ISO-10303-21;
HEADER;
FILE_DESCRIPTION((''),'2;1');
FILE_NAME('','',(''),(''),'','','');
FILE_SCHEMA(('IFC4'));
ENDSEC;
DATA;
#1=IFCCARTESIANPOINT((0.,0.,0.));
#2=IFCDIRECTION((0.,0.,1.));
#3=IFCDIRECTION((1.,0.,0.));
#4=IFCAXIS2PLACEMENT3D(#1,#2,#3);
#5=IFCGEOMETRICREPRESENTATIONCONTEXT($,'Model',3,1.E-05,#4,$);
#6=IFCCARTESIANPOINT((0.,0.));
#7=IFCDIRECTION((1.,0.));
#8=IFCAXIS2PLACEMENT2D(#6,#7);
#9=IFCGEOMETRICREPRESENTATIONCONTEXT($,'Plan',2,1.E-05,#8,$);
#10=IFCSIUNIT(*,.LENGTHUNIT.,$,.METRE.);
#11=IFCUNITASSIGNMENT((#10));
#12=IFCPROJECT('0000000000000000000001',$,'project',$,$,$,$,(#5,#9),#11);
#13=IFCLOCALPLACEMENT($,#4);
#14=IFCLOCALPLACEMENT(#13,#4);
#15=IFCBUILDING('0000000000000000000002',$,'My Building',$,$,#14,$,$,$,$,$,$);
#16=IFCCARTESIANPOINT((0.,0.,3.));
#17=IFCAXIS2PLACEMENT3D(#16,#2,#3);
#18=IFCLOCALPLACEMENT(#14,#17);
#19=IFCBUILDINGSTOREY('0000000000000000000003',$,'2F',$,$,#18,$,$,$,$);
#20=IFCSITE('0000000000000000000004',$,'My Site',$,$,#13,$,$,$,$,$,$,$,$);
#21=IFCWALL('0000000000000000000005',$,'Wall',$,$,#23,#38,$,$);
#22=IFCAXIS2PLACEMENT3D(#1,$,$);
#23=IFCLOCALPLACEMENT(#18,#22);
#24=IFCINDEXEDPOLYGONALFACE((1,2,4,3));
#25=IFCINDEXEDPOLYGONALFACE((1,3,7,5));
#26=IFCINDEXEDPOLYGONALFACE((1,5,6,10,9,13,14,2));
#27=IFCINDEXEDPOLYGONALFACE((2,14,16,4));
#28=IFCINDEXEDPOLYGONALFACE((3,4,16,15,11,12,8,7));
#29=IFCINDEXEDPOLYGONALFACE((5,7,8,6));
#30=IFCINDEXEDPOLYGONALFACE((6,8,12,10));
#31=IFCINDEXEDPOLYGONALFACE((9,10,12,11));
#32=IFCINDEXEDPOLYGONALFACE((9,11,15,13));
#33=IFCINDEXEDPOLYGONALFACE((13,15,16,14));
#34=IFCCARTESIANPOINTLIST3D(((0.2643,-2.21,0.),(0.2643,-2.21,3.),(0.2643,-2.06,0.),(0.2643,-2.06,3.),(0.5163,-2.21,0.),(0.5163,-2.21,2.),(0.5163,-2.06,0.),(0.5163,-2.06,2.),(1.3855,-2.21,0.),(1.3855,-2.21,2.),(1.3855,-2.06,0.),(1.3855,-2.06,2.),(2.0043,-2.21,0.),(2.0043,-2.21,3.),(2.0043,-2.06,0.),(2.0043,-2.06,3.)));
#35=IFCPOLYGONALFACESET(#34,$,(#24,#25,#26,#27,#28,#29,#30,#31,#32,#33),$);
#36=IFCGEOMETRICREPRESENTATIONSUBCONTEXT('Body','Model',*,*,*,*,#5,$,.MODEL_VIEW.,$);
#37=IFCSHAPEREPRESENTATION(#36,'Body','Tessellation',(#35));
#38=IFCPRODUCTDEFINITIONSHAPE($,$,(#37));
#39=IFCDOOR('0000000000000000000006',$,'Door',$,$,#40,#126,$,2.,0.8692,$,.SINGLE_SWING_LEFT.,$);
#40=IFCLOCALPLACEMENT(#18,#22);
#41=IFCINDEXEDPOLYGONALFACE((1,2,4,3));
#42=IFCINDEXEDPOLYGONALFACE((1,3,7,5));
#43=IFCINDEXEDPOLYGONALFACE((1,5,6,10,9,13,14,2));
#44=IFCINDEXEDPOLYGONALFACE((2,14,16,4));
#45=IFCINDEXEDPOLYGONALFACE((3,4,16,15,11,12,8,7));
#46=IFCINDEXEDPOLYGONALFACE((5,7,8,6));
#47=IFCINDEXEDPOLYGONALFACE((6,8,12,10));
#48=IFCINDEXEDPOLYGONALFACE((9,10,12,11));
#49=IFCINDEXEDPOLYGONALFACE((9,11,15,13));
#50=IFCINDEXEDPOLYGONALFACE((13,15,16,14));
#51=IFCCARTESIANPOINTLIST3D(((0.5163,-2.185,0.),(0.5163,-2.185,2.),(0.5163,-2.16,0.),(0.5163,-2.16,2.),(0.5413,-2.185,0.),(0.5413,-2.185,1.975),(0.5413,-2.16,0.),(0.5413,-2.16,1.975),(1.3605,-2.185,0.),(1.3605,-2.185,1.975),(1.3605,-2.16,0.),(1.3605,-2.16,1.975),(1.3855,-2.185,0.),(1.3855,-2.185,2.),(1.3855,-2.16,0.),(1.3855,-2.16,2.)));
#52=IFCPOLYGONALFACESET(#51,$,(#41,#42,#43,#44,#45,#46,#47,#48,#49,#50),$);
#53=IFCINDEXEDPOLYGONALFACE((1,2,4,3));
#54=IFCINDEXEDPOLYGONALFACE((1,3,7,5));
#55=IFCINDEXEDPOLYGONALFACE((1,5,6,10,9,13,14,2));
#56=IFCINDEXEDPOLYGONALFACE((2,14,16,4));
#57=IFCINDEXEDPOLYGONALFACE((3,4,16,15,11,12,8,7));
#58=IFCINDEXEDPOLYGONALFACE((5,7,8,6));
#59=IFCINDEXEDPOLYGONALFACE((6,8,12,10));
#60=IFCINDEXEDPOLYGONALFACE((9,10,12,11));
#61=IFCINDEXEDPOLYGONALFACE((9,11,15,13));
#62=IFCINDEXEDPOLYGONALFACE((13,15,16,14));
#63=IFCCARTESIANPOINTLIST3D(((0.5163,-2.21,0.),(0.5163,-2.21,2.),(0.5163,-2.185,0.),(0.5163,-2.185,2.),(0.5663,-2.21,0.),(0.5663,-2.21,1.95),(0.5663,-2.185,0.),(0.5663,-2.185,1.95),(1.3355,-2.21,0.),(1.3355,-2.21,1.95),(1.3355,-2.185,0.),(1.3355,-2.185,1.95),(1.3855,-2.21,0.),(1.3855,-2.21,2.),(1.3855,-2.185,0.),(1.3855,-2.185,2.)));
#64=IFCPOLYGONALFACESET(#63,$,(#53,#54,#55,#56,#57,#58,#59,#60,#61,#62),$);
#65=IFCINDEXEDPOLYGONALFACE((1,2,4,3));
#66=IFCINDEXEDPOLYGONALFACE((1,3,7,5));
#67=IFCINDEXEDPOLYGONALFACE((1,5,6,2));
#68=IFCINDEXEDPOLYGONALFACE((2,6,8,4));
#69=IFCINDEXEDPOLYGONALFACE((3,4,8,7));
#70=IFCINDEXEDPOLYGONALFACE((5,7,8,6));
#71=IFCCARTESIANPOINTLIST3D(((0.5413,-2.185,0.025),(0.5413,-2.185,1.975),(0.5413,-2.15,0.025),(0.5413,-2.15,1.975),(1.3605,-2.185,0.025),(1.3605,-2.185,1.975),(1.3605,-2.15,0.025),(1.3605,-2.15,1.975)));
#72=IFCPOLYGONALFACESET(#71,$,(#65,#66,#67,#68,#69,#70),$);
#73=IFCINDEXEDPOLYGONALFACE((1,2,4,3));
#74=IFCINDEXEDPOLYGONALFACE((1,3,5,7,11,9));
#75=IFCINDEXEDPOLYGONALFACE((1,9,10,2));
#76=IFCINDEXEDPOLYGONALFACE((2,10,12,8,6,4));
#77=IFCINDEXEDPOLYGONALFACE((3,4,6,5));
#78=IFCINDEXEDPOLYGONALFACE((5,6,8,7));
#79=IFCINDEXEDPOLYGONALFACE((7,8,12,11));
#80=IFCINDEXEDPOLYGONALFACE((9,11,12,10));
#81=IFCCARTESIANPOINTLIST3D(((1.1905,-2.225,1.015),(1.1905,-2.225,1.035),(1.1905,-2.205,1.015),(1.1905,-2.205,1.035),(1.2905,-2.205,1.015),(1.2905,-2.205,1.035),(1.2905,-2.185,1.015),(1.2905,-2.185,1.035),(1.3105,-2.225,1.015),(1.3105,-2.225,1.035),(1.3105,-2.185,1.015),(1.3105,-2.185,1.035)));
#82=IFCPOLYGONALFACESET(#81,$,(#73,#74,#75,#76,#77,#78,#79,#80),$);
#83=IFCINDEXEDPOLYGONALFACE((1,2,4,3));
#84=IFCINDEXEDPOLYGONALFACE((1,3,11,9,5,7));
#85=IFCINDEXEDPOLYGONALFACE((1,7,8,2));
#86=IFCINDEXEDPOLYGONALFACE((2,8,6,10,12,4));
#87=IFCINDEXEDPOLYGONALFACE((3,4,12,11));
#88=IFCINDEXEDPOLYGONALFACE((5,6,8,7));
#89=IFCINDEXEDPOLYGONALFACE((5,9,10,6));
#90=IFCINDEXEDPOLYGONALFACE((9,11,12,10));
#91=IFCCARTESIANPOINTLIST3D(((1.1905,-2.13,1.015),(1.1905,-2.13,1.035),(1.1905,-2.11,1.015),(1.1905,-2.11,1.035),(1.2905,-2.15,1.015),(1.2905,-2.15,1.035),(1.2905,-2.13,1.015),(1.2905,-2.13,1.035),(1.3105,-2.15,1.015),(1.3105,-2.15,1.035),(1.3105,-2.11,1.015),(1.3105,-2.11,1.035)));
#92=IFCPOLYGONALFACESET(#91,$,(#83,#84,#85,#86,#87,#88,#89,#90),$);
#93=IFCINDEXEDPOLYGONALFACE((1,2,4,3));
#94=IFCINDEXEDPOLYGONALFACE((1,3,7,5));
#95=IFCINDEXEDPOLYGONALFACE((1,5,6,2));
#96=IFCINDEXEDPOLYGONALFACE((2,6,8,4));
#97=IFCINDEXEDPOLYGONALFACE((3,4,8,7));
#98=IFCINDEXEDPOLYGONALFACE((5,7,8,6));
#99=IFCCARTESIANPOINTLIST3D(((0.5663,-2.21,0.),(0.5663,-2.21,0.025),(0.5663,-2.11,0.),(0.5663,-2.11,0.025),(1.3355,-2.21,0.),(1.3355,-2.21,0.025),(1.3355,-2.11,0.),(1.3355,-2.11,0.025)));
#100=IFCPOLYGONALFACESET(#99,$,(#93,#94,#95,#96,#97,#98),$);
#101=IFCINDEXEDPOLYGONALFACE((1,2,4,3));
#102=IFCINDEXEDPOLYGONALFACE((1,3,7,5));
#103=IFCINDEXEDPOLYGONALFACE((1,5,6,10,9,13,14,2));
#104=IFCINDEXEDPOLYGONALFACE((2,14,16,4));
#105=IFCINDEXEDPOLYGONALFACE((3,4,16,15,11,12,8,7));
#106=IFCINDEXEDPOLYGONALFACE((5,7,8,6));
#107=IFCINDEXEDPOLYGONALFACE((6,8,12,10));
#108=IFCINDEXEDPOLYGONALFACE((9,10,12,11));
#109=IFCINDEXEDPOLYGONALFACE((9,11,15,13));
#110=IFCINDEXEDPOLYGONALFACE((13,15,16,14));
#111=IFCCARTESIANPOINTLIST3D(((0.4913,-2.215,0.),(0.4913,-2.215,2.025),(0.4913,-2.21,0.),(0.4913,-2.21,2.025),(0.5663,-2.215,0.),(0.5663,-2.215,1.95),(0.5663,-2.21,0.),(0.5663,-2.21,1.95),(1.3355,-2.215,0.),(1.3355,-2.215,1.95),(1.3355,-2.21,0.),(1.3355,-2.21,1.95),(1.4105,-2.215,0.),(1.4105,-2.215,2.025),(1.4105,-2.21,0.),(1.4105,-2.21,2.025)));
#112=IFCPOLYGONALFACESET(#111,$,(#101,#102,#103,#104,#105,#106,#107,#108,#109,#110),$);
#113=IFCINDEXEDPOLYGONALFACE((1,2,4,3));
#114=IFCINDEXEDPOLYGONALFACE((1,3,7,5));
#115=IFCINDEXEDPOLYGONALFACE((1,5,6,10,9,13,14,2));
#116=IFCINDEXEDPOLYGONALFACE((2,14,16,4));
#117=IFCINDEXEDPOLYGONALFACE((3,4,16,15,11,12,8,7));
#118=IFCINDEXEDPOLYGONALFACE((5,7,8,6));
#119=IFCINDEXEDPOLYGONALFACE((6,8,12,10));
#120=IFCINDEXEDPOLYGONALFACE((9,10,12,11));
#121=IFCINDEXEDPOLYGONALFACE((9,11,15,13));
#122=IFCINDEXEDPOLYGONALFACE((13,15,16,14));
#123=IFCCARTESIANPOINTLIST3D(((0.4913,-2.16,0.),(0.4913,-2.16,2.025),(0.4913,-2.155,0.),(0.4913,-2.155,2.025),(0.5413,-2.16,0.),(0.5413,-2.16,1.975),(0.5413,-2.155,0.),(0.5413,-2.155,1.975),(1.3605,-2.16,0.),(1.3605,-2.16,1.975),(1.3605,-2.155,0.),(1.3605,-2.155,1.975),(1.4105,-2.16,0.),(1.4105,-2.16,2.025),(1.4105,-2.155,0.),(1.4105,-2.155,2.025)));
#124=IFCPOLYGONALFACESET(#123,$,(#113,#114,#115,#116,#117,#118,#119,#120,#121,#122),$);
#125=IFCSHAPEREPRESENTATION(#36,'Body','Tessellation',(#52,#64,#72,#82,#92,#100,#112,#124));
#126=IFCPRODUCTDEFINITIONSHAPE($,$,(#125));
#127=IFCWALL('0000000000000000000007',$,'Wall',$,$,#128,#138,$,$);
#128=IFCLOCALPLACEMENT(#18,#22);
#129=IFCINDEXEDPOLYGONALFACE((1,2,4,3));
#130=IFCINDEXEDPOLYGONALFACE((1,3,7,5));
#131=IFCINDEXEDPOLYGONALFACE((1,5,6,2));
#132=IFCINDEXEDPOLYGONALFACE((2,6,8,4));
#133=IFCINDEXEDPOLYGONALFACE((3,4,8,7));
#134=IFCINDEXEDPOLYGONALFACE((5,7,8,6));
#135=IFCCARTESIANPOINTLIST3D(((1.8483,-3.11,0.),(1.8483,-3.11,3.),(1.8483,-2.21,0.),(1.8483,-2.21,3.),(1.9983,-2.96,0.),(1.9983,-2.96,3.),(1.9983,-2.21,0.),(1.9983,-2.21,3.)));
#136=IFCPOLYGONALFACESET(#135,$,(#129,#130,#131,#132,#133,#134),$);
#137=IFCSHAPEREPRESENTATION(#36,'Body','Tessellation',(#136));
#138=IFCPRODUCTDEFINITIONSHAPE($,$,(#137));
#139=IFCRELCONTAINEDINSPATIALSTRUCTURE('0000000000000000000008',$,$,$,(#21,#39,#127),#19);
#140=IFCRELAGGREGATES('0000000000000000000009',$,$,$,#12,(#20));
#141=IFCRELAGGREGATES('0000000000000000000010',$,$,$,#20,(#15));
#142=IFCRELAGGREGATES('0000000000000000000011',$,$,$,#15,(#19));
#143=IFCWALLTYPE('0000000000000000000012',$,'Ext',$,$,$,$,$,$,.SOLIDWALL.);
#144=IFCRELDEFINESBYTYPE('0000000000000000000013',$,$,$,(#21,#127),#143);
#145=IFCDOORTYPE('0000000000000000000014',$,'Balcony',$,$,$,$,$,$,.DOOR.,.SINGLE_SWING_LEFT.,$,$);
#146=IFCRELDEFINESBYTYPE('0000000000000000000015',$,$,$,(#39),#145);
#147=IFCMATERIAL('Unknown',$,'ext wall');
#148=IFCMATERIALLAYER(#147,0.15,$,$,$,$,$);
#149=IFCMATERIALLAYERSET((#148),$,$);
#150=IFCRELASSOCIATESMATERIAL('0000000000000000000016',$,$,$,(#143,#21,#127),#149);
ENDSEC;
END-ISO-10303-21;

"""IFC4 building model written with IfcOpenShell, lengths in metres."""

from ifc_helpers import new_model, entity, si_unit, frame, origin_with_axes, origin_2d_with_axis, place, context, subcontext, project, spatial, line, indexed_curve, outline, extrude, shape, source, transform, mapped, material, layer, layer_set, layer_usage, type_object, type_shapes, element, fill, save


model = new_model("IFC4")

# Units and contexts
model_context = context("Model", 3, precision=1e-05, world=origin_with_axes())
plan_context = context("Plan", 2, precision=1e-05, world=origin_2d_with_axis())
body_context_1 = subcontext(model_context, "Body", "Model", "MODEL_VIEW")
body_context_2 = subcontext(plan_context, "Body", "Plan", "PLAN_VIEW")
ifc_project = project(units=[si_unit("LENGTHUNIT", "METRE")], contexts=[model_context, plan_context])

# Site, building, storey
site_placement = place(None, origin_with_axes())
site = spatial("IfcSite", under=ifc_project, at=site_placement, Name="My Site")
building_placement = place(site_placement, origin_with_axes())
building = spatial("IfcBuilding", under=site, at=building_placement, Name="My Building")
storey_placement = place(building_placement, frame((0.0, 0.0, 3.0), z_axis=(0.0, 0.0, 1.0), x_axis=(1.0, 0.0, 0.0)))
storey = spatial("IfcBuildingStorey", under=building, at=storey_placement, Name="2F")

# Shared definitions
ifc_material = material(Name="Unknown", Category="ext wall")

# Wall, opening, door
ifc_layer_1 = layer(ifc_material, 0.15)
ifc_layer_set_1 = layer_set([ifc_layer_1])
ifc_layer_usage_1 = layer_usage(ifc_layer_set_1, "AXIS2", "POSITIVE", 0.0)
wall_type_1 = type_object("IfcWallType", Name="Ext", PredefinedType="SOLIDWALL", material=ifc_layer_set_1)
wall_1_placement = place(storey_placement, frame((0.2643, -2.21, 0.0), z_axis=(0.0, 0.0, 1.0), x_axis=(1.0, 0.0, 0.0)))
wall_1 = element("IfcWall", 1, at=wall_1_placement, inside=storey, type_object=wall_type_1, material=ifc_layer_usage_1, Name="Wall", context=body_context_1, shape_type="SweptSolid", body=[
    extrude(outline(indexed_curve([(0.0, 0.0), (0.0, 0.15), (1.74, 0.15), (1.74, 0.0)], segments=[line(1, 2, 3, 4, 1)])), origin_with_axes(), (0.0, 0.0, 1.0), 3.0),
])
shared_shape_1 = source(origin_with_axes(), body_context_1, "Body", "SweptSolid", [
    extrude(outline(indexed_curve([(0.0, 0.0), (0.8692, 0.0), (0.8692, 2.0), (0.0, 2.0)], segments=[line(1, 2, 3, 4, 1)])), frame((0.0, -0.6, 0.0), z_axis=(0.0, -1.0, 0.0), x_axis=(1.0, 0.0, 0.0)), (0.0, 0.0, -1.0), 1.2),
])
opening_1_placement = place(wall_1_placement, frame((0.252, 0.0, 0.0), z_axis=(0.0, 0.0, 1.0), x_axis=(1.0, 0.0, 0.0)))
opening_1 = element("IfcOpeningElement", 2, at=opening_1_placement, cuts=wall_1, PredefinedType="OPENING", context=body_context_1, shape_type="MappedRepresentation", body=[
    mapped(shared_shape_1, transform((0.0, 0.0, 0.0), x_axis=(1.0, 0.0, 0.0), y_axis=(0.0, 1.0, 0.0), z_axis=(0.0, 0.0, 1.0), scale=1.0)),
])
door_type_1 = type_object("IfcDoorType", Name="Balcony", OperationType="SINGLE_SWING_LEFT", PredefinedType="DOOR")
shared_shape_2 = source(origin_with_axes(), body_context_1, "Body", "SweptSolid", [
    extrude(outline(indexed_curve([(0.0, 0.0), (0.0, 2.0), (0.8692, 2.0), (0.8692, 0.0), (0.8442, 0.0), (0.8442, 1.975), (0.025, 1.975), (0.025, 0.0)], segments=[line(1, 2, 3, 4, 5, 6, 7, 8, 1)])), frame((0.0, 0.025, 0.0), z_axis=(0.0, -1.0, 0.0), x_axis=(1.0, 0.0, 0.0)), (0.0, 0.0, -1.0), 0.025),
    extrude(outline(indexed_curve([(0.0, 0.0), (0.0, 2.0), (0.8692, 2.0), (0.8692, 0.0), (0.8192, 0.0), (0.8192, 1.95), (0.05, 1.95), (0.05, 0.0)], segments=[line(1, 2, 3, 4, 5, 6, 7, 8, 1)])), frame((0.0, 0.0, 0.0), z_axis=(0.0, -1.0, 0.0), x_axis=(1.0, 0.0, 0.0)), (0.0, 0.0, -1.0), 0.025),
    extrude(outline(indexed_curve([(0.0, 0.0), (0.8192, 0.0), (0.8192, 0.035), (0.0, 0.035)], segments=[line(1, 2, 3, 4, 1)])), frame((0.025, 0.025, 0.025), z_axis=(0.0, 0.0, 1.0), x_axis=(1.0, 0.0, 0.0)), (0.0, 0.0, 1.0), 1.95),
    extrude(outline(indexed_curve([(0.0, 0.0), (0.0, -0.04), (-0.12, -0.04), (-0.12, -0.02), (-0.02, -0.02), (-0.02, 0.0)], segments=[line(1, 2, 3, 4, 5, 6, 1)])), frame((0.7942, 0.025, 1.015), z_axis=(0.0, 0.0, 1.0), x_axis=(1.0, 0.0, 0.0)), (0.0, 0.0, 1.0), 0.02),
    extrude(outline(indexed_curve([(0.0, 0.0), (0.0, 0.04), (-0.12, 0.04), (-0.12, 0.02), (-0.02, 0.02), (-0.02, 0.0)], segments=[line(1, 2, 3, 4, 5, 6, 1)])), frame((0.7942, 0.06, 1.015), z_axis=(0.0, 0.0, 1.0), x_axis=(1.0, 0.0, 0.0)), (0.0, 0.0, 1.0), 0.02),
    extrude(outline(indexed_curve([(0.0, 0.0), (0.7692, 0.0), (0.7692, 0.1), (0.0, 0.1)], segments=[line(1, 2, 3, 4, 1)])), frame((0.05, 0.0, 0.0), z_axis=(0.0, 0.0, 1.0), x_axis=(1.0, 0.0, 0.0)), (0.0, 0.0, 1.0), 0.025),
    extrude(outline(indexed_curve([(0.0, 0.0), (0.0, 2.025), (0.9192, 2.025), (0.9192, 0.0), (0.8442, 0.0), (0.8442, 1.95), (0.075, 1.95), (0.075, 0.0)], segments=[line(1, 2, 3, 4, 5, 6, 7, 8, 1)])), frame((-0.025, -0.005, 0.0), z_axis=(0.0, -1.0, 0.0), x_axis=(1.0, 0.0, 0.0)), (0.0, 0.0, -1.0), 0.005),
    extrude(outline(indexed_curve([(0.0, 0.0), (0.0, 2.025), (0.9192, 2.025), (0.9192, 0.0), (0.8692, 0.0), (0.8692, 1.975), (0.05, 1.975), (0.05, 0.0)], segments=[line(1, 2, 3, 4, 5, 6, 7, 8, 1)])), frame((-0.025, 0.05, 0.0), z_axis=(0.0, -1.0, 0.0), x_axis=(1.0, 0.0, 0.0)), (0.0, 0.0, -1.0), 0.005),
])
shared_shape_3 = source(origin_with_axes(), body_context_2, "Body", "Curve2D", [
    entity("IfcIndexedPolyCurve", entity("IfcCartesianPointList2D", [[0.0, 0.0], [0.0, 0.05], [0.025, 0.05], [0.025, 0.025], [0.05, 0.025], [0.05, 0.0]]), [entity("IfcLineIndex", [1, 2, 3, 4, 5, 6, 1])]),
    entity("IfcIndexedPolyCurve", entity("IfcCartesianPointList2D", [[0.8692, 0.0], [0.8692, 0.05], [0.8442, 0.05], [0.8442, 0.025], [0.8192, 0.025], [0.8192, 0.0]]), [entity("IfcLineIndex", [1, 2, 3, 4, 5, 6, 1])]),
    entity("IfcTrimmedCurve", entity("IfcEllipse", entity("IfcAxis2Placement2D", entity("IfcCartesianPoint", [0.06, 0.05]), entity("IfcDirection", [1.0, 0.0])), 0.7842, 0.8192), [entity("IfcCartesianPoint", [0.8442, 0.05])], [entity("IfcCartesianPoint", [0.06, 0.8692])], True, "CARTESIAN"),
    entity("IfcIndexedPolyCurve", entity("IfcCartesianPointList2D", [[0.025, 0.05], [0.06, 0.05], [0.06, 0.8692], [0.025, 0.8692]]), [entity("IfcLineIndex", [1, 2, 3, 4, 1])]),
])
type_shapes(door_type_1, [shared_shape_2, shared_shape_3])
door_1_placement = place(opening_1_placement, frame((0.0, 0.0, 0.0), z_axis=(0.0, 0.0, 1.0), x_axis=(1.0, 0.0, 0.0)))
door_1 = element("IfcDoor", 3, at=door_1_placement, inside=storey, type_object=door_type_1, Name="Door", OperationType="SINGLE_SWING_LEFT", OverallHeight=2.0, OverallWidth=0.8692, shapes=[
    shape(body_context_1, "Body", "MappedRepresentation", [mapped(shared_shape_2, transform((0.0, 0.0, 0.0), x_axis=(1.0, 0.0, 0.0), y_axis=(0.0, 1.0, 0.0), z_axis=(0.0, 0.0, 1.0), scale=1.0))]),
    shape(body_context_2, "Body", "MappedRepresentation", [mapped(shared_shape_3, transform((0.0, 0.0, 0.0), x_axis=(1.0, 0.0, 0.0), y_axis=(0.0, 1.0, 0.0), z_axis=(0.0, 0.0, 1.0), scale=1.0))]),
])
fill(opening_1, door_1)

# Wall
ifc_layer_usage_2 = layer_usage(ifc_layer_set_1, "AXIS2", "POSITIVE", 0.0)
wall_2_placement = place(storey_placement, frame((1.8483, -2.21, 0.0), z_axis=(0.0, 0.0, 1.0), x_axis=(0.0, -1.0, 0.0)))
element("IfcWall", 4, at=wall_2_placement, inside=storey, type_object=wall_type_1, material=ifc_layer_usage_2, Name="Wall", context=body_context_1, shape_type="SweptSolid", body=[
    extrude(outline(indexed_curve([(0.0, 0.0), (0.0, 0.15), (0.75, 0.15), (0.9, 0.0)], segments=[line(1, 2, 3, 4, 1)])), origin_with_axes(), (0.0, 0.0, 1.0), 3.0),
])

save(model, "model.ifc")
